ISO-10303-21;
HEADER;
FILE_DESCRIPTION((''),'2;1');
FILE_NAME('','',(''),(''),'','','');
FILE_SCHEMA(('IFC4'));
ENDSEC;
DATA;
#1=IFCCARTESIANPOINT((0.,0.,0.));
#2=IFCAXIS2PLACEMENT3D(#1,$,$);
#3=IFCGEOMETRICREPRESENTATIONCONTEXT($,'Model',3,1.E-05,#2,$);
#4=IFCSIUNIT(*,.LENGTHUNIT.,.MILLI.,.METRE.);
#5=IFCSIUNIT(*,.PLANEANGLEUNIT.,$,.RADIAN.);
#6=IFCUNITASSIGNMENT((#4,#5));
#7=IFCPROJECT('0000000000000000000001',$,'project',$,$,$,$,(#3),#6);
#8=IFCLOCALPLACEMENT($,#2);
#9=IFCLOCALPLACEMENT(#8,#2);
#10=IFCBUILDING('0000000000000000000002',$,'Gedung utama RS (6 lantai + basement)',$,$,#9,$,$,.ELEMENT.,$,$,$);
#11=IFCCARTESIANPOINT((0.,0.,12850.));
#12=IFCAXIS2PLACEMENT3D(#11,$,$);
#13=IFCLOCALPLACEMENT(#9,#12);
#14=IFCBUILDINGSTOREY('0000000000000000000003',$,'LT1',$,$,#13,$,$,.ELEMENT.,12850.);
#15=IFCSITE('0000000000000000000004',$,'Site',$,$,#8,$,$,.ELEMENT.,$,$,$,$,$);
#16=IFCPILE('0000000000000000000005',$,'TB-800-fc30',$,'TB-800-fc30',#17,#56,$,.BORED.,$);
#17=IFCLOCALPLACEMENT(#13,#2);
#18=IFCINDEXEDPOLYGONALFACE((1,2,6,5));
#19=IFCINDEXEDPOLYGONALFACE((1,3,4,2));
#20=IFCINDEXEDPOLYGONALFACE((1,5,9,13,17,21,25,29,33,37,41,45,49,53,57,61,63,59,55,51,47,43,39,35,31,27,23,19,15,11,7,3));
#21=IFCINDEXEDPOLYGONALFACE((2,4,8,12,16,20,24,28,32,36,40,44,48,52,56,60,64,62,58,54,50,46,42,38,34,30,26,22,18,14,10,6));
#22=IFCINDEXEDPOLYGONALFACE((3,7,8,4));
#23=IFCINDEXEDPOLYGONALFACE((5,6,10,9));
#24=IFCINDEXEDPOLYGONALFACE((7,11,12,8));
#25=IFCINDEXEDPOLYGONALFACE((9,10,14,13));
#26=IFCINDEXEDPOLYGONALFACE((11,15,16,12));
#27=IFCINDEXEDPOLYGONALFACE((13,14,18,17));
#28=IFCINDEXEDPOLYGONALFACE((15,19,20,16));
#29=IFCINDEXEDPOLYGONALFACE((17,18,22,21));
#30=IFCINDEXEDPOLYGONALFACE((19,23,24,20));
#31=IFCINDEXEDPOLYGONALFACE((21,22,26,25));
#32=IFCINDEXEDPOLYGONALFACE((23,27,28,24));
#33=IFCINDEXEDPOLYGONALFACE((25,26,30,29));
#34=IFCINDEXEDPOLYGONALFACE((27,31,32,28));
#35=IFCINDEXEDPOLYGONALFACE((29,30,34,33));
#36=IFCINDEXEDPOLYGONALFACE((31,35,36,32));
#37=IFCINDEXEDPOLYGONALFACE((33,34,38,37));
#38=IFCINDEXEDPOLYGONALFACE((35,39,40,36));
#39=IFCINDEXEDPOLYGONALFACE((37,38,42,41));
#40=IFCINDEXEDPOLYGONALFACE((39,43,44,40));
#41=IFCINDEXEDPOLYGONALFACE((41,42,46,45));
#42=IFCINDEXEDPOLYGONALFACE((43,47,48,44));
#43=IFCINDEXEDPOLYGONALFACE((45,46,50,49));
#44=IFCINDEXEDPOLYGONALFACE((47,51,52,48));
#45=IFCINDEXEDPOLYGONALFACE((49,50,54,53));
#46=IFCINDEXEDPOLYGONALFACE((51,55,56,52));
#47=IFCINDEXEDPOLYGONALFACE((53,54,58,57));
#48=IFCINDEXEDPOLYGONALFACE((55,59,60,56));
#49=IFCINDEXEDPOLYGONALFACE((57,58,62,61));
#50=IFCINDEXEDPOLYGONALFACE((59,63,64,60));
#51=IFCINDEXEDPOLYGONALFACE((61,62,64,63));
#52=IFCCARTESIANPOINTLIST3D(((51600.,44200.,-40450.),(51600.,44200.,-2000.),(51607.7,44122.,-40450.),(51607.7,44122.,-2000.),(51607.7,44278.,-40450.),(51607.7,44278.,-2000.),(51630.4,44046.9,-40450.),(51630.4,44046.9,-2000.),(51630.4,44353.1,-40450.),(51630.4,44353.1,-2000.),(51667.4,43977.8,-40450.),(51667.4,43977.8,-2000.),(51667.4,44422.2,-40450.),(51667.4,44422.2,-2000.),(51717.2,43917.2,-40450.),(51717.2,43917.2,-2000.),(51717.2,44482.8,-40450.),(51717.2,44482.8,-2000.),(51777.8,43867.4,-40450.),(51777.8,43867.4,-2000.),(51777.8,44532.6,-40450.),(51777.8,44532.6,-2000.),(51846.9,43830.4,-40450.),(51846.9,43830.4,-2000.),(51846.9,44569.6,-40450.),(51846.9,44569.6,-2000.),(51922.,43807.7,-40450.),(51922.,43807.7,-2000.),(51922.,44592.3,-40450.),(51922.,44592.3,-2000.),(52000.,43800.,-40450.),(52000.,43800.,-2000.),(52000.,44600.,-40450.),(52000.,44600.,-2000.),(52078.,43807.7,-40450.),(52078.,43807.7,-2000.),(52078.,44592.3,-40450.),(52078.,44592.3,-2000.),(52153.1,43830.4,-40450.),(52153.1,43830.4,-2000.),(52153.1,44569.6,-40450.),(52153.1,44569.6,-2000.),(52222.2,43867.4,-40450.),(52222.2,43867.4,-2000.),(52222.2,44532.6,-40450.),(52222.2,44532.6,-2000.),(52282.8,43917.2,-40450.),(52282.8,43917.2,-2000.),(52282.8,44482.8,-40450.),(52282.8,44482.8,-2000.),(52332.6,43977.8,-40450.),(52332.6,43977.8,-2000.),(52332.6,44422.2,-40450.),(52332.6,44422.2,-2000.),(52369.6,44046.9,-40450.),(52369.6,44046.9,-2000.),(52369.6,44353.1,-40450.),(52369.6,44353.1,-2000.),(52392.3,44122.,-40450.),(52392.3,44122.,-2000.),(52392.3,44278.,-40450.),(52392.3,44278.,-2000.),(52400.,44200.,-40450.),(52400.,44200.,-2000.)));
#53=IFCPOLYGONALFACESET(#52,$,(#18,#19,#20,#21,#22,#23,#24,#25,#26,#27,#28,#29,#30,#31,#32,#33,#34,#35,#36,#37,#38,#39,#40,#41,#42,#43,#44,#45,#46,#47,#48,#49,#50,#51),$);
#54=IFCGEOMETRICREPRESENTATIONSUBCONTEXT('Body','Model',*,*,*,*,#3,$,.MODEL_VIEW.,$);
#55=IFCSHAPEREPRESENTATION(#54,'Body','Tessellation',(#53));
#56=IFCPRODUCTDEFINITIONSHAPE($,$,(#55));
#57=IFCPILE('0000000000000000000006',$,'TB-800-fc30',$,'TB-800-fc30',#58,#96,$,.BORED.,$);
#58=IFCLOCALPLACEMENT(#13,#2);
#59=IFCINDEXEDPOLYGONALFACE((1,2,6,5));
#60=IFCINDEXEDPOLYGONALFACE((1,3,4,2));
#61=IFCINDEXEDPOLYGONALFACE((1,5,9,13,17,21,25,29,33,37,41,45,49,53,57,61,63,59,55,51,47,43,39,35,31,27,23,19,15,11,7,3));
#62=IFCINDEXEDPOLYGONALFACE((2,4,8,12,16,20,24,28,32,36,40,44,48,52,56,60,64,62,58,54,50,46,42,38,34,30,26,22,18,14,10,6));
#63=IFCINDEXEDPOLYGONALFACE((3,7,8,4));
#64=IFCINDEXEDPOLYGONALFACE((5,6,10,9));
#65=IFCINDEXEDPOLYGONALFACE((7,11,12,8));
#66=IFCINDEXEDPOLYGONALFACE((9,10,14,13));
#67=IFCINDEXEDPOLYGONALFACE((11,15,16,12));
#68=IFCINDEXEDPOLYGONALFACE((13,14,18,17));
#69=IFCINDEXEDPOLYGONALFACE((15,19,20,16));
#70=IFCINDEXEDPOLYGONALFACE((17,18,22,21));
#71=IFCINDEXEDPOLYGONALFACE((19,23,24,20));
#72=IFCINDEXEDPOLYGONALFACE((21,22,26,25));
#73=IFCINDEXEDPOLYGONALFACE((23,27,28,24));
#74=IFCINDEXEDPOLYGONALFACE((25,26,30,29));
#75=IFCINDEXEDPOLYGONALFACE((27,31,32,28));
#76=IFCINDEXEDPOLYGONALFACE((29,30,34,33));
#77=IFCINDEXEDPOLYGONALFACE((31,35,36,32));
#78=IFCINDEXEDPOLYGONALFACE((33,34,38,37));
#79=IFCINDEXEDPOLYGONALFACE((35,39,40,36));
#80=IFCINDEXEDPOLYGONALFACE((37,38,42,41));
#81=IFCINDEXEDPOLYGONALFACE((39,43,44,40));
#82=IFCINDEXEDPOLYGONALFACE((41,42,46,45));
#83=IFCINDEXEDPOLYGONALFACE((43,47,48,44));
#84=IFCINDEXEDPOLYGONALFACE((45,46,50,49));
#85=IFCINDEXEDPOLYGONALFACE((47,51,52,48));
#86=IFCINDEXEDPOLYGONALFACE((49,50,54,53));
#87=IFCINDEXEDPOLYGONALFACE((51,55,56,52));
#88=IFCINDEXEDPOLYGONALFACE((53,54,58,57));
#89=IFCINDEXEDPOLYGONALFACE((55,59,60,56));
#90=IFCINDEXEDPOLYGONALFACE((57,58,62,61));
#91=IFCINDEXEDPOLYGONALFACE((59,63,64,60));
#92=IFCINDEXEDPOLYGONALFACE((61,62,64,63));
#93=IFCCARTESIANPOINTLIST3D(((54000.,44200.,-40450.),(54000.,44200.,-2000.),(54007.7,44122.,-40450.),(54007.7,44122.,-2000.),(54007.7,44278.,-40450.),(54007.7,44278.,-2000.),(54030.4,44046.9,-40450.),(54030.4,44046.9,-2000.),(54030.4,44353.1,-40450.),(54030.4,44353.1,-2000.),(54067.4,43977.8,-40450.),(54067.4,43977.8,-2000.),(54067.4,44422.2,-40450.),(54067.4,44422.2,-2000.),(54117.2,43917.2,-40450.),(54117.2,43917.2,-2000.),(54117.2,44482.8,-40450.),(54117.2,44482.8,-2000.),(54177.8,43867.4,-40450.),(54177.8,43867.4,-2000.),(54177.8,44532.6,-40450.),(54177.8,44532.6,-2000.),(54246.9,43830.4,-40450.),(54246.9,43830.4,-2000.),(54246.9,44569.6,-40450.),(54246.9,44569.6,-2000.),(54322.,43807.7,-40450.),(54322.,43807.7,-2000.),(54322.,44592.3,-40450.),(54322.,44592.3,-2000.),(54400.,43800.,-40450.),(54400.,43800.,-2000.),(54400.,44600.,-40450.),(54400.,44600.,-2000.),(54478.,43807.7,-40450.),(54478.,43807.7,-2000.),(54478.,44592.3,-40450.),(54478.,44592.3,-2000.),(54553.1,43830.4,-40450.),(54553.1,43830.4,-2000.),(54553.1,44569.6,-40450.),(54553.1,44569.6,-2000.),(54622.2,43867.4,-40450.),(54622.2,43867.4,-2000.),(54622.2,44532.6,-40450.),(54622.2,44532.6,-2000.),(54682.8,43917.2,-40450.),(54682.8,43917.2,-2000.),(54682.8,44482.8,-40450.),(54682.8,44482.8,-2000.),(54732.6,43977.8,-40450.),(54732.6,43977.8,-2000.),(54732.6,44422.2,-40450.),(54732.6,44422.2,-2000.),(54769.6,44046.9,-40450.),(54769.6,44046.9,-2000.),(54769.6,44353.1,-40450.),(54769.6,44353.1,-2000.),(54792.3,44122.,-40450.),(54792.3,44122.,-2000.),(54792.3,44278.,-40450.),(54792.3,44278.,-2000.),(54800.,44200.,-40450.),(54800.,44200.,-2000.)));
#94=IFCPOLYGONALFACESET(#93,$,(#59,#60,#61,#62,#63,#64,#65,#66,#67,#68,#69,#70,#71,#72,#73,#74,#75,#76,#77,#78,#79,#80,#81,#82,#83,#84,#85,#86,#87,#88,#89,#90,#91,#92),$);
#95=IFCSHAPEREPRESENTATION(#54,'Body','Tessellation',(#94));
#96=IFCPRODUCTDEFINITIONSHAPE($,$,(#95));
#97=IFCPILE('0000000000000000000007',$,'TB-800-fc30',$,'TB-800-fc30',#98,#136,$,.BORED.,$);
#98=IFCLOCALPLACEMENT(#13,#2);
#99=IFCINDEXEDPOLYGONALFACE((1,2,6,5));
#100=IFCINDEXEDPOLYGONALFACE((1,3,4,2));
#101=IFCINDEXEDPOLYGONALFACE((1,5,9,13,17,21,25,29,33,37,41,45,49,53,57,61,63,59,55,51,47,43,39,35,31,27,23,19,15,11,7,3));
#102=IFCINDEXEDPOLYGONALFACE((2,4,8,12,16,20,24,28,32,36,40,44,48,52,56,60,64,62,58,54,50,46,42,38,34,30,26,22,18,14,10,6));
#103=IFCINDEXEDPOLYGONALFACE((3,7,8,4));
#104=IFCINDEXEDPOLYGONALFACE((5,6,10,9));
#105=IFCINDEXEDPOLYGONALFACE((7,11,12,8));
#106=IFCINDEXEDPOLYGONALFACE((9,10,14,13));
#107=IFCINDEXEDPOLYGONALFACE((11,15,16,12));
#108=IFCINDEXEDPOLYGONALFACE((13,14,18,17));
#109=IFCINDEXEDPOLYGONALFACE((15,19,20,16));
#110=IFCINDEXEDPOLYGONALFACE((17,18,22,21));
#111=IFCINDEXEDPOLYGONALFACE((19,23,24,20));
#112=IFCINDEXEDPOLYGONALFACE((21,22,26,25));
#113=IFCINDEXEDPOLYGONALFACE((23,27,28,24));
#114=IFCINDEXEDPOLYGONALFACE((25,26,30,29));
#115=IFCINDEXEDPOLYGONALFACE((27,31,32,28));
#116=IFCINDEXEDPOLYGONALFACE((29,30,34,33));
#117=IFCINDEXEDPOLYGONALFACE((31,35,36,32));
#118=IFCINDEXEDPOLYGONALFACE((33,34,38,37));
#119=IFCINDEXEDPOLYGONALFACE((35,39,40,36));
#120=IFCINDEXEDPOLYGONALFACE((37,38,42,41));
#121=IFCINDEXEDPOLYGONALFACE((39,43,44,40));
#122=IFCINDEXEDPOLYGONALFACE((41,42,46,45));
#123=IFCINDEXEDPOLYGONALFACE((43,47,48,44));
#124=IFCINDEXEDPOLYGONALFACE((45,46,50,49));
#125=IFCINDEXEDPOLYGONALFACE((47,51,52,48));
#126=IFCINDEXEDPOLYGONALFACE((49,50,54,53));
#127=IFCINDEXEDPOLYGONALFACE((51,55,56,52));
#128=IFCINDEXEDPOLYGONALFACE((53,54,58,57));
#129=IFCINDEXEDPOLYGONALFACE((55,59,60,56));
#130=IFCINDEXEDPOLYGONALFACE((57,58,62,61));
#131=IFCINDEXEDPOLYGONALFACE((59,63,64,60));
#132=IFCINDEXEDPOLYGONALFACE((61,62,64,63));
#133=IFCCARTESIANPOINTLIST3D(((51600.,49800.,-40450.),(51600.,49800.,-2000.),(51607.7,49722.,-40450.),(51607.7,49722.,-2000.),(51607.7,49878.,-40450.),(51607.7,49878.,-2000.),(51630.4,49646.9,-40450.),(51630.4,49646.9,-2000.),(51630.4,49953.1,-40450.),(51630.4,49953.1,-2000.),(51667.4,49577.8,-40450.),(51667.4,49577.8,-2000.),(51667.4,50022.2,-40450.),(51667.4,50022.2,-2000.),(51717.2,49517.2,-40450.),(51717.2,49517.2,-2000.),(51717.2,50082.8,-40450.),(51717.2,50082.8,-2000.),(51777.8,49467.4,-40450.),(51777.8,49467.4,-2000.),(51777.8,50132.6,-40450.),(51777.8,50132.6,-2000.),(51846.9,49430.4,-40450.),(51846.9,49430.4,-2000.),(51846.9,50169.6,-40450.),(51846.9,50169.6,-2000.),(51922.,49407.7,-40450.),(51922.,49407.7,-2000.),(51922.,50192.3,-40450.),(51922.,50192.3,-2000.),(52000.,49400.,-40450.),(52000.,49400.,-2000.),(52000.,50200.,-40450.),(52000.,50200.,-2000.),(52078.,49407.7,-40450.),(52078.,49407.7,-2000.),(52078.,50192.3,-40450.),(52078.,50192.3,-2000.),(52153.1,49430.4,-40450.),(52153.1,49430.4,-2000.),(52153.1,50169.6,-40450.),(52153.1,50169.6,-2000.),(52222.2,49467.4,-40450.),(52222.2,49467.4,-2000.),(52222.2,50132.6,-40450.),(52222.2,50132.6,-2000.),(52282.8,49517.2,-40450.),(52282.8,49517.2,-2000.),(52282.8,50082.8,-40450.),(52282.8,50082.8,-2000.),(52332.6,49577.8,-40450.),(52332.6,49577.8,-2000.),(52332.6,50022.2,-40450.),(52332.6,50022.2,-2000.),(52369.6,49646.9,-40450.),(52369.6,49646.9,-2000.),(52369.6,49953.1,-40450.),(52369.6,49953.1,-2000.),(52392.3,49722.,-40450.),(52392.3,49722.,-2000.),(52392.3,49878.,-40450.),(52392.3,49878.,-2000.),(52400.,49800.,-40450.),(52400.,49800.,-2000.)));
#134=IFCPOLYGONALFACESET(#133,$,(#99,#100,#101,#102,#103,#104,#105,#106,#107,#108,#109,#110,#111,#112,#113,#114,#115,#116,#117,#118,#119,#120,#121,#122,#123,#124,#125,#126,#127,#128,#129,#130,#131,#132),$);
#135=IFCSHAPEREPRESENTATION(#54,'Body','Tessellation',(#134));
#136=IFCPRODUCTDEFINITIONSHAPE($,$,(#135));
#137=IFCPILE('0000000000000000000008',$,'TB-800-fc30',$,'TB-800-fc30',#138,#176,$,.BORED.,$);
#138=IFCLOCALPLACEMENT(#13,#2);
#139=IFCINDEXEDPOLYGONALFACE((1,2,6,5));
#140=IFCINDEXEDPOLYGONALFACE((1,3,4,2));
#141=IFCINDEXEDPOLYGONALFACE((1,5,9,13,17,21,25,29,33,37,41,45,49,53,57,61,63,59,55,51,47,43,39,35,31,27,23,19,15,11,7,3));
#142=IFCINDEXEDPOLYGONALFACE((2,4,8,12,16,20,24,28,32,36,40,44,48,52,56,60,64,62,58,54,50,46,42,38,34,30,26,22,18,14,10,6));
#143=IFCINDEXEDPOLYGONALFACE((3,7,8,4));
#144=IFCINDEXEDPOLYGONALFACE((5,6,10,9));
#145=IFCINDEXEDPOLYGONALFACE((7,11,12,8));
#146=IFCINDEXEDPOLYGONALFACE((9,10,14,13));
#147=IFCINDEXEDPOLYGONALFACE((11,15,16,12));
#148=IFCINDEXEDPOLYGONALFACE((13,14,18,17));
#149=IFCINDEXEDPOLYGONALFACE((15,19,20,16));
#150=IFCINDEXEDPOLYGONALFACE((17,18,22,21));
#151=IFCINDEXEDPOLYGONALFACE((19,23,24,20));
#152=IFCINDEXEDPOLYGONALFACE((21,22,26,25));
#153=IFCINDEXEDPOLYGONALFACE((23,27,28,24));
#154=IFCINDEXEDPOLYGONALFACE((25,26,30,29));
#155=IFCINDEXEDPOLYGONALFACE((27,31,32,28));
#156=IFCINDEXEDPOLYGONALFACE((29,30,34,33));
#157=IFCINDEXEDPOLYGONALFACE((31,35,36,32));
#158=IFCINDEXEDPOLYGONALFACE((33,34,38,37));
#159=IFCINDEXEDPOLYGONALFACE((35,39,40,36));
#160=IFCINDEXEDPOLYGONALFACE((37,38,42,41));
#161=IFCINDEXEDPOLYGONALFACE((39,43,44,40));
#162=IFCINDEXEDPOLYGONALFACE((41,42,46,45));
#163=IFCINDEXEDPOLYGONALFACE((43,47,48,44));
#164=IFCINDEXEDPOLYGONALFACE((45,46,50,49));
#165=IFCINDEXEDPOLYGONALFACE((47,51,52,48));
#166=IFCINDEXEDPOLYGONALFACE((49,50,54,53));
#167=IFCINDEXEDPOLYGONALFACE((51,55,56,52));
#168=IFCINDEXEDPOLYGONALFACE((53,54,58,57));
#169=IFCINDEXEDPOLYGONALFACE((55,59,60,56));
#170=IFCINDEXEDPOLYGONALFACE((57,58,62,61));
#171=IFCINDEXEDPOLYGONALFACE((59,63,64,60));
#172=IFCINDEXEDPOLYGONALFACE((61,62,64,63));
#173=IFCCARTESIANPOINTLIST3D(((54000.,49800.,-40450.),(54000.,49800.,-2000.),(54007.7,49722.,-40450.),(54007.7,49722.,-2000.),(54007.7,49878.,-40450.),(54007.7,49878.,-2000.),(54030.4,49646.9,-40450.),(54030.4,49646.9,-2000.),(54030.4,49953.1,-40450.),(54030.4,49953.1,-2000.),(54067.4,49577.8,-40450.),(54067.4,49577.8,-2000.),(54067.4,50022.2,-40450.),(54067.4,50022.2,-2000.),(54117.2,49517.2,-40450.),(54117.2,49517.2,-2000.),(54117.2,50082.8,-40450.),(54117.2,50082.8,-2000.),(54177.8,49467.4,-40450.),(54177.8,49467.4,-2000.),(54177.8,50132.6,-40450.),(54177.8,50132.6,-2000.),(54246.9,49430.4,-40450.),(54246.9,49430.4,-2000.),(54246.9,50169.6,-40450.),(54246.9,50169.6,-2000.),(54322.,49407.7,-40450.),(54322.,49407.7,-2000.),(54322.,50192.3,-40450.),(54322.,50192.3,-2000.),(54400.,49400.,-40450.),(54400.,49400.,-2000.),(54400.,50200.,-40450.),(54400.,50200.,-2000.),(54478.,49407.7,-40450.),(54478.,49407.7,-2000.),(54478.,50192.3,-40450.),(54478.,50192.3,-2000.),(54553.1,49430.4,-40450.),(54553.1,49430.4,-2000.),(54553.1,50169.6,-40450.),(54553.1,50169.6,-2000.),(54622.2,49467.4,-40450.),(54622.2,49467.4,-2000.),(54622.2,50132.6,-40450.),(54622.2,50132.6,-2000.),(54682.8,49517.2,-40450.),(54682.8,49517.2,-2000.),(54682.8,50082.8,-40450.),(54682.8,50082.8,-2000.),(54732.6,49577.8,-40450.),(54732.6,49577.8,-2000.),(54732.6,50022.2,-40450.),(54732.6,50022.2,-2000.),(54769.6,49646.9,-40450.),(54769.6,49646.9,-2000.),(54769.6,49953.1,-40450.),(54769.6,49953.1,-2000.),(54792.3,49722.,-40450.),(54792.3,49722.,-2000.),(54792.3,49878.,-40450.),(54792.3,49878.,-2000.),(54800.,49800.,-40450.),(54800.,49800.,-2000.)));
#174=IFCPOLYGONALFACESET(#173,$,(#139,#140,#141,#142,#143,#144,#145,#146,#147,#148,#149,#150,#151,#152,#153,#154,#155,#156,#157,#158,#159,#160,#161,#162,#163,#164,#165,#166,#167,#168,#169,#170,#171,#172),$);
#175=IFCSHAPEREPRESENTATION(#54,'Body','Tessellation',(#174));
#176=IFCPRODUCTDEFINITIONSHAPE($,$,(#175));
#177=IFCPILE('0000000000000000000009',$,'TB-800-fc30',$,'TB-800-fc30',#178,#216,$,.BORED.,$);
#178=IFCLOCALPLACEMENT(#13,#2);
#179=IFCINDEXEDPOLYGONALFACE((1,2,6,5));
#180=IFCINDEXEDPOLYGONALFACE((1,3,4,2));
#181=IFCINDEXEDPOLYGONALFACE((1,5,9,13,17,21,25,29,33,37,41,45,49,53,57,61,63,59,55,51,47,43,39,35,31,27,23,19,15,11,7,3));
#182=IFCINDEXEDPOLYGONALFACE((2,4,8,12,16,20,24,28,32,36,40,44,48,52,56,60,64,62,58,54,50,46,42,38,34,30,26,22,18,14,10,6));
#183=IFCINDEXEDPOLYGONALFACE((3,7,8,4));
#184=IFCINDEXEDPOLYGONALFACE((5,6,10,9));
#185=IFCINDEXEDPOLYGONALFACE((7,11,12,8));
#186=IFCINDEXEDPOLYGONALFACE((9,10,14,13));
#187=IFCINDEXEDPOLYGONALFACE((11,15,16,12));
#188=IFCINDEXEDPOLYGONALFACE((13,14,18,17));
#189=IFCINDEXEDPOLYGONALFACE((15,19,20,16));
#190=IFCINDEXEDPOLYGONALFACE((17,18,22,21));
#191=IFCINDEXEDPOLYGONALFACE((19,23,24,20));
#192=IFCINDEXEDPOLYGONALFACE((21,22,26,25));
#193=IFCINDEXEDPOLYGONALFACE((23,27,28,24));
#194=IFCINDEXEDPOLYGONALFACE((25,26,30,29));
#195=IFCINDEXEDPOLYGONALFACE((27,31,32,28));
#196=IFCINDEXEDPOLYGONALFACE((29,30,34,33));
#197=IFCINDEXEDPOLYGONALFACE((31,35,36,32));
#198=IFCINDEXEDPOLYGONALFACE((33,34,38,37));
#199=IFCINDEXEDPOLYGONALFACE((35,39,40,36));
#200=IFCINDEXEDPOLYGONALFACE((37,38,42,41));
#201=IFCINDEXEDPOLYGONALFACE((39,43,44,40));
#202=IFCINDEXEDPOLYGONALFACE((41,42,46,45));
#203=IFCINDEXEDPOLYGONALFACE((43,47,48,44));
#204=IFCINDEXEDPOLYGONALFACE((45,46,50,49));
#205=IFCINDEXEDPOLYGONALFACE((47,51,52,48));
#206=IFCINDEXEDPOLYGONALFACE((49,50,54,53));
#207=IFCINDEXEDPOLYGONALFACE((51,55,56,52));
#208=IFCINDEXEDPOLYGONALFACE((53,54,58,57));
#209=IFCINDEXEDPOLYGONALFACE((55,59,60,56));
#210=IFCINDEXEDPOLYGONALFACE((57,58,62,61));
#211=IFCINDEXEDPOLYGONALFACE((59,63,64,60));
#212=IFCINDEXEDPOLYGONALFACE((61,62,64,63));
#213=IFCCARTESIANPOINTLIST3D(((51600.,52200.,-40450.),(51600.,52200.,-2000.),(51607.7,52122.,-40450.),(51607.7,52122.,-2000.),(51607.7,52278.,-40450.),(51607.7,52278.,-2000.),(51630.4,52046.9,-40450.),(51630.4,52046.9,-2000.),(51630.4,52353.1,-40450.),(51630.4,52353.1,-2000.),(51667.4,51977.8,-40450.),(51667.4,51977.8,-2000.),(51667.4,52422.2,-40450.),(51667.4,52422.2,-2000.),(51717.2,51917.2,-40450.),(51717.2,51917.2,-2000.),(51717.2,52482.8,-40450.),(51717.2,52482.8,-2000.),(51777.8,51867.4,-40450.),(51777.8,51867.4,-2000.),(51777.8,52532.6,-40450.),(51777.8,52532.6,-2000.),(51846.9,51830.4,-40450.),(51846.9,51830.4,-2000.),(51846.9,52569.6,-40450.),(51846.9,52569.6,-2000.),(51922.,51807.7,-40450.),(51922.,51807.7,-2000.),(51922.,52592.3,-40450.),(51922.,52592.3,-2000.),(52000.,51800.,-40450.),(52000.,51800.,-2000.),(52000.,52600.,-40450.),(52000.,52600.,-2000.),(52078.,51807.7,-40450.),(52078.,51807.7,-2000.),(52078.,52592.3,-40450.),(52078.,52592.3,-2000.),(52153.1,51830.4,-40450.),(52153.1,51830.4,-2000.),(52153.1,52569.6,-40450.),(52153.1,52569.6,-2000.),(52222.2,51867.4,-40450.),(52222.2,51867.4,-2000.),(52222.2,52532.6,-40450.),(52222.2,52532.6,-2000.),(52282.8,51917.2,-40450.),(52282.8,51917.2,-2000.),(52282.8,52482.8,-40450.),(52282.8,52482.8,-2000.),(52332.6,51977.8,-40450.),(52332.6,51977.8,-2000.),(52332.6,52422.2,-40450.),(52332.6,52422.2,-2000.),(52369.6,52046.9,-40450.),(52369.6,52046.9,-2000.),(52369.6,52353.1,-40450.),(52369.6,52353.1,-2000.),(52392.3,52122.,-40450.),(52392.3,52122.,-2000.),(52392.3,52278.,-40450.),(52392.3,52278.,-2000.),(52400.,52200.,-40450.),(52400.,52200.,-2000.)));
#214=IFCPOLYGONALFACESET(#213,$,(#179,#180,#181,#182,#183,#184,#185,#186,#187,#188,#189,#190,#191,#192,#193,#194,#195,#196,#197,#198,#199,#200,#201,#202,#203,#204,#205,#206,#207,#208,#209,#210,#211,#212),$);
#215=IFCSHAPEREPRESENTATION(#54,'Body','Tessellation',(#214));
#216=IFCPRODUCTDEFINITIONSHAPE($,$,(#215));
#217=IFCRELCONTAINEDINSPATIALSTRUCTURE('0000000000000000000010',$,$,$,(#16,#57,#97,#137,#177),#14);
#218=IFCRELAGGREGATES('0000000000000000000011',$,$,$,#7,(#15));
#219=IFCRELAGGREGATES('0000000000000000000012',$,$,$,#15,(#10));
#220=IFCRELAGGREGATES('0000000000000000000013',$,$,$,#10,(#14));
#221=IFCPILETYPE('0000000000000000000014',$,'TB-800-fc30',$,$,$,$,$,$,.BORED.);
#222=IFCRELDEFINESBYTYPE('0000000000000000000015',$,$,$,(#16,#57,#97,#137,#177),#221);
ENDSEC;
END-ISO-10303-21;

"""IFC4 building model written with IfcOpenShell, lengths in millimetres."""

from ifc_helpers import new_model, si_unit, frame, origin, origin_2d, place, context, subcontext, project, spatial, circle, extrude, material_profile, profile_set, profile_usage, type_object, element, save


model = new_model("IFC4")

# Units and contexts
model_context = context("Model", 3, precision=1e-05, world=origin())
body_context = subcontext(model_context, "Body", "Model", "MODEL_VIEW")
ifc_project = project(units=[si_unit("LENGTHUNIT", "METRE", prefix="MILLI"), si_unit("PLANEANGLEUNIT", "RADIAN")], contexts=[model_context])

# Site, building, storey
site_placement = place(None, origin())
site = spatial("IfcSite", under=ifc_project, at=site_placement, Name="Site", CompositionType="ELEMENT")
building_placement = place(site_placement, origin())
building = spatial("IfcBuilding", under=site, at=building_placement, Name="Gedung utama RS (6 lantai + basement)", CompositionType="ELEMENT")
storey_placement = place(building_placement, frame((0.0, 0.0, 12850.0)))
storey = spatial("IfcBuildingStorey", under=building, at=storey_placement, Name="LT1", CompositionType="ELEMENT", Elevation=12850.0)

# Piles
ifc_material_profile_1 = material_profile(None, circle(Radius=400.0, at=origin_2d()), Name="TB-800-fc30")
ifc_profile_set_1 = profile_set([ifc_material_profile_1], Name="TB-800-fc30")
ifc_profile_usage_1 = profile_usage(ifc_profile_set_1, cardinal=5)
pile_type = type_object("IfcPileType", Name="TB-800-fc30", PredefinedType="BORED", material=ifc_profile_set_1)
for number, where, z_axis, x_axis, name in (
    (1, (52000.0, 44200.0, -40450.0), (0.0, 0.0, 1.0), (1.0, 0.0, 0.0), "TB-800-fc30"),
    (2, (54400.0, 44200.0, -40450.0), (0.0, 0.0, 1.0), (1.0, 0.0, 0.0), "TB-800-fc30"),
    (3, (52000.0, 49800.0, -40450.0), (0.0, 0.0, 1.0), (1.0, 0.0, 0.0), "TB-800-fc30"),
    (4, (54400.0, 49800.0, -40450.0), (0.0, 0.0, 1.0), (1.0, 0.0, 0.0), "TB-800-fc30"),
    (5, (52000.0, 52200.0, -40450.0), (0.0, 0.0, 1.0), (1.0, 0.0, 0.0), "TB-800-fc30"),
):
    element("IfcPile", number, at=place(storey_placement, frame(where, z_axis=z_axis, x_axis=x_axis)), inside=storey, type_object=pile_type, material=ifc_profile_usage_1, Name=name, ObjectType="TB-800-fc30", PredefinedType="BORED", context=body_context, shape_type="SweptSolid", body=[
        extrude(circle(Radius=400.0, at=origin_2d()), origin(), (0.0, 0.0, 1.0), 38450.0),
    ])

save(model, "model.ifc")
